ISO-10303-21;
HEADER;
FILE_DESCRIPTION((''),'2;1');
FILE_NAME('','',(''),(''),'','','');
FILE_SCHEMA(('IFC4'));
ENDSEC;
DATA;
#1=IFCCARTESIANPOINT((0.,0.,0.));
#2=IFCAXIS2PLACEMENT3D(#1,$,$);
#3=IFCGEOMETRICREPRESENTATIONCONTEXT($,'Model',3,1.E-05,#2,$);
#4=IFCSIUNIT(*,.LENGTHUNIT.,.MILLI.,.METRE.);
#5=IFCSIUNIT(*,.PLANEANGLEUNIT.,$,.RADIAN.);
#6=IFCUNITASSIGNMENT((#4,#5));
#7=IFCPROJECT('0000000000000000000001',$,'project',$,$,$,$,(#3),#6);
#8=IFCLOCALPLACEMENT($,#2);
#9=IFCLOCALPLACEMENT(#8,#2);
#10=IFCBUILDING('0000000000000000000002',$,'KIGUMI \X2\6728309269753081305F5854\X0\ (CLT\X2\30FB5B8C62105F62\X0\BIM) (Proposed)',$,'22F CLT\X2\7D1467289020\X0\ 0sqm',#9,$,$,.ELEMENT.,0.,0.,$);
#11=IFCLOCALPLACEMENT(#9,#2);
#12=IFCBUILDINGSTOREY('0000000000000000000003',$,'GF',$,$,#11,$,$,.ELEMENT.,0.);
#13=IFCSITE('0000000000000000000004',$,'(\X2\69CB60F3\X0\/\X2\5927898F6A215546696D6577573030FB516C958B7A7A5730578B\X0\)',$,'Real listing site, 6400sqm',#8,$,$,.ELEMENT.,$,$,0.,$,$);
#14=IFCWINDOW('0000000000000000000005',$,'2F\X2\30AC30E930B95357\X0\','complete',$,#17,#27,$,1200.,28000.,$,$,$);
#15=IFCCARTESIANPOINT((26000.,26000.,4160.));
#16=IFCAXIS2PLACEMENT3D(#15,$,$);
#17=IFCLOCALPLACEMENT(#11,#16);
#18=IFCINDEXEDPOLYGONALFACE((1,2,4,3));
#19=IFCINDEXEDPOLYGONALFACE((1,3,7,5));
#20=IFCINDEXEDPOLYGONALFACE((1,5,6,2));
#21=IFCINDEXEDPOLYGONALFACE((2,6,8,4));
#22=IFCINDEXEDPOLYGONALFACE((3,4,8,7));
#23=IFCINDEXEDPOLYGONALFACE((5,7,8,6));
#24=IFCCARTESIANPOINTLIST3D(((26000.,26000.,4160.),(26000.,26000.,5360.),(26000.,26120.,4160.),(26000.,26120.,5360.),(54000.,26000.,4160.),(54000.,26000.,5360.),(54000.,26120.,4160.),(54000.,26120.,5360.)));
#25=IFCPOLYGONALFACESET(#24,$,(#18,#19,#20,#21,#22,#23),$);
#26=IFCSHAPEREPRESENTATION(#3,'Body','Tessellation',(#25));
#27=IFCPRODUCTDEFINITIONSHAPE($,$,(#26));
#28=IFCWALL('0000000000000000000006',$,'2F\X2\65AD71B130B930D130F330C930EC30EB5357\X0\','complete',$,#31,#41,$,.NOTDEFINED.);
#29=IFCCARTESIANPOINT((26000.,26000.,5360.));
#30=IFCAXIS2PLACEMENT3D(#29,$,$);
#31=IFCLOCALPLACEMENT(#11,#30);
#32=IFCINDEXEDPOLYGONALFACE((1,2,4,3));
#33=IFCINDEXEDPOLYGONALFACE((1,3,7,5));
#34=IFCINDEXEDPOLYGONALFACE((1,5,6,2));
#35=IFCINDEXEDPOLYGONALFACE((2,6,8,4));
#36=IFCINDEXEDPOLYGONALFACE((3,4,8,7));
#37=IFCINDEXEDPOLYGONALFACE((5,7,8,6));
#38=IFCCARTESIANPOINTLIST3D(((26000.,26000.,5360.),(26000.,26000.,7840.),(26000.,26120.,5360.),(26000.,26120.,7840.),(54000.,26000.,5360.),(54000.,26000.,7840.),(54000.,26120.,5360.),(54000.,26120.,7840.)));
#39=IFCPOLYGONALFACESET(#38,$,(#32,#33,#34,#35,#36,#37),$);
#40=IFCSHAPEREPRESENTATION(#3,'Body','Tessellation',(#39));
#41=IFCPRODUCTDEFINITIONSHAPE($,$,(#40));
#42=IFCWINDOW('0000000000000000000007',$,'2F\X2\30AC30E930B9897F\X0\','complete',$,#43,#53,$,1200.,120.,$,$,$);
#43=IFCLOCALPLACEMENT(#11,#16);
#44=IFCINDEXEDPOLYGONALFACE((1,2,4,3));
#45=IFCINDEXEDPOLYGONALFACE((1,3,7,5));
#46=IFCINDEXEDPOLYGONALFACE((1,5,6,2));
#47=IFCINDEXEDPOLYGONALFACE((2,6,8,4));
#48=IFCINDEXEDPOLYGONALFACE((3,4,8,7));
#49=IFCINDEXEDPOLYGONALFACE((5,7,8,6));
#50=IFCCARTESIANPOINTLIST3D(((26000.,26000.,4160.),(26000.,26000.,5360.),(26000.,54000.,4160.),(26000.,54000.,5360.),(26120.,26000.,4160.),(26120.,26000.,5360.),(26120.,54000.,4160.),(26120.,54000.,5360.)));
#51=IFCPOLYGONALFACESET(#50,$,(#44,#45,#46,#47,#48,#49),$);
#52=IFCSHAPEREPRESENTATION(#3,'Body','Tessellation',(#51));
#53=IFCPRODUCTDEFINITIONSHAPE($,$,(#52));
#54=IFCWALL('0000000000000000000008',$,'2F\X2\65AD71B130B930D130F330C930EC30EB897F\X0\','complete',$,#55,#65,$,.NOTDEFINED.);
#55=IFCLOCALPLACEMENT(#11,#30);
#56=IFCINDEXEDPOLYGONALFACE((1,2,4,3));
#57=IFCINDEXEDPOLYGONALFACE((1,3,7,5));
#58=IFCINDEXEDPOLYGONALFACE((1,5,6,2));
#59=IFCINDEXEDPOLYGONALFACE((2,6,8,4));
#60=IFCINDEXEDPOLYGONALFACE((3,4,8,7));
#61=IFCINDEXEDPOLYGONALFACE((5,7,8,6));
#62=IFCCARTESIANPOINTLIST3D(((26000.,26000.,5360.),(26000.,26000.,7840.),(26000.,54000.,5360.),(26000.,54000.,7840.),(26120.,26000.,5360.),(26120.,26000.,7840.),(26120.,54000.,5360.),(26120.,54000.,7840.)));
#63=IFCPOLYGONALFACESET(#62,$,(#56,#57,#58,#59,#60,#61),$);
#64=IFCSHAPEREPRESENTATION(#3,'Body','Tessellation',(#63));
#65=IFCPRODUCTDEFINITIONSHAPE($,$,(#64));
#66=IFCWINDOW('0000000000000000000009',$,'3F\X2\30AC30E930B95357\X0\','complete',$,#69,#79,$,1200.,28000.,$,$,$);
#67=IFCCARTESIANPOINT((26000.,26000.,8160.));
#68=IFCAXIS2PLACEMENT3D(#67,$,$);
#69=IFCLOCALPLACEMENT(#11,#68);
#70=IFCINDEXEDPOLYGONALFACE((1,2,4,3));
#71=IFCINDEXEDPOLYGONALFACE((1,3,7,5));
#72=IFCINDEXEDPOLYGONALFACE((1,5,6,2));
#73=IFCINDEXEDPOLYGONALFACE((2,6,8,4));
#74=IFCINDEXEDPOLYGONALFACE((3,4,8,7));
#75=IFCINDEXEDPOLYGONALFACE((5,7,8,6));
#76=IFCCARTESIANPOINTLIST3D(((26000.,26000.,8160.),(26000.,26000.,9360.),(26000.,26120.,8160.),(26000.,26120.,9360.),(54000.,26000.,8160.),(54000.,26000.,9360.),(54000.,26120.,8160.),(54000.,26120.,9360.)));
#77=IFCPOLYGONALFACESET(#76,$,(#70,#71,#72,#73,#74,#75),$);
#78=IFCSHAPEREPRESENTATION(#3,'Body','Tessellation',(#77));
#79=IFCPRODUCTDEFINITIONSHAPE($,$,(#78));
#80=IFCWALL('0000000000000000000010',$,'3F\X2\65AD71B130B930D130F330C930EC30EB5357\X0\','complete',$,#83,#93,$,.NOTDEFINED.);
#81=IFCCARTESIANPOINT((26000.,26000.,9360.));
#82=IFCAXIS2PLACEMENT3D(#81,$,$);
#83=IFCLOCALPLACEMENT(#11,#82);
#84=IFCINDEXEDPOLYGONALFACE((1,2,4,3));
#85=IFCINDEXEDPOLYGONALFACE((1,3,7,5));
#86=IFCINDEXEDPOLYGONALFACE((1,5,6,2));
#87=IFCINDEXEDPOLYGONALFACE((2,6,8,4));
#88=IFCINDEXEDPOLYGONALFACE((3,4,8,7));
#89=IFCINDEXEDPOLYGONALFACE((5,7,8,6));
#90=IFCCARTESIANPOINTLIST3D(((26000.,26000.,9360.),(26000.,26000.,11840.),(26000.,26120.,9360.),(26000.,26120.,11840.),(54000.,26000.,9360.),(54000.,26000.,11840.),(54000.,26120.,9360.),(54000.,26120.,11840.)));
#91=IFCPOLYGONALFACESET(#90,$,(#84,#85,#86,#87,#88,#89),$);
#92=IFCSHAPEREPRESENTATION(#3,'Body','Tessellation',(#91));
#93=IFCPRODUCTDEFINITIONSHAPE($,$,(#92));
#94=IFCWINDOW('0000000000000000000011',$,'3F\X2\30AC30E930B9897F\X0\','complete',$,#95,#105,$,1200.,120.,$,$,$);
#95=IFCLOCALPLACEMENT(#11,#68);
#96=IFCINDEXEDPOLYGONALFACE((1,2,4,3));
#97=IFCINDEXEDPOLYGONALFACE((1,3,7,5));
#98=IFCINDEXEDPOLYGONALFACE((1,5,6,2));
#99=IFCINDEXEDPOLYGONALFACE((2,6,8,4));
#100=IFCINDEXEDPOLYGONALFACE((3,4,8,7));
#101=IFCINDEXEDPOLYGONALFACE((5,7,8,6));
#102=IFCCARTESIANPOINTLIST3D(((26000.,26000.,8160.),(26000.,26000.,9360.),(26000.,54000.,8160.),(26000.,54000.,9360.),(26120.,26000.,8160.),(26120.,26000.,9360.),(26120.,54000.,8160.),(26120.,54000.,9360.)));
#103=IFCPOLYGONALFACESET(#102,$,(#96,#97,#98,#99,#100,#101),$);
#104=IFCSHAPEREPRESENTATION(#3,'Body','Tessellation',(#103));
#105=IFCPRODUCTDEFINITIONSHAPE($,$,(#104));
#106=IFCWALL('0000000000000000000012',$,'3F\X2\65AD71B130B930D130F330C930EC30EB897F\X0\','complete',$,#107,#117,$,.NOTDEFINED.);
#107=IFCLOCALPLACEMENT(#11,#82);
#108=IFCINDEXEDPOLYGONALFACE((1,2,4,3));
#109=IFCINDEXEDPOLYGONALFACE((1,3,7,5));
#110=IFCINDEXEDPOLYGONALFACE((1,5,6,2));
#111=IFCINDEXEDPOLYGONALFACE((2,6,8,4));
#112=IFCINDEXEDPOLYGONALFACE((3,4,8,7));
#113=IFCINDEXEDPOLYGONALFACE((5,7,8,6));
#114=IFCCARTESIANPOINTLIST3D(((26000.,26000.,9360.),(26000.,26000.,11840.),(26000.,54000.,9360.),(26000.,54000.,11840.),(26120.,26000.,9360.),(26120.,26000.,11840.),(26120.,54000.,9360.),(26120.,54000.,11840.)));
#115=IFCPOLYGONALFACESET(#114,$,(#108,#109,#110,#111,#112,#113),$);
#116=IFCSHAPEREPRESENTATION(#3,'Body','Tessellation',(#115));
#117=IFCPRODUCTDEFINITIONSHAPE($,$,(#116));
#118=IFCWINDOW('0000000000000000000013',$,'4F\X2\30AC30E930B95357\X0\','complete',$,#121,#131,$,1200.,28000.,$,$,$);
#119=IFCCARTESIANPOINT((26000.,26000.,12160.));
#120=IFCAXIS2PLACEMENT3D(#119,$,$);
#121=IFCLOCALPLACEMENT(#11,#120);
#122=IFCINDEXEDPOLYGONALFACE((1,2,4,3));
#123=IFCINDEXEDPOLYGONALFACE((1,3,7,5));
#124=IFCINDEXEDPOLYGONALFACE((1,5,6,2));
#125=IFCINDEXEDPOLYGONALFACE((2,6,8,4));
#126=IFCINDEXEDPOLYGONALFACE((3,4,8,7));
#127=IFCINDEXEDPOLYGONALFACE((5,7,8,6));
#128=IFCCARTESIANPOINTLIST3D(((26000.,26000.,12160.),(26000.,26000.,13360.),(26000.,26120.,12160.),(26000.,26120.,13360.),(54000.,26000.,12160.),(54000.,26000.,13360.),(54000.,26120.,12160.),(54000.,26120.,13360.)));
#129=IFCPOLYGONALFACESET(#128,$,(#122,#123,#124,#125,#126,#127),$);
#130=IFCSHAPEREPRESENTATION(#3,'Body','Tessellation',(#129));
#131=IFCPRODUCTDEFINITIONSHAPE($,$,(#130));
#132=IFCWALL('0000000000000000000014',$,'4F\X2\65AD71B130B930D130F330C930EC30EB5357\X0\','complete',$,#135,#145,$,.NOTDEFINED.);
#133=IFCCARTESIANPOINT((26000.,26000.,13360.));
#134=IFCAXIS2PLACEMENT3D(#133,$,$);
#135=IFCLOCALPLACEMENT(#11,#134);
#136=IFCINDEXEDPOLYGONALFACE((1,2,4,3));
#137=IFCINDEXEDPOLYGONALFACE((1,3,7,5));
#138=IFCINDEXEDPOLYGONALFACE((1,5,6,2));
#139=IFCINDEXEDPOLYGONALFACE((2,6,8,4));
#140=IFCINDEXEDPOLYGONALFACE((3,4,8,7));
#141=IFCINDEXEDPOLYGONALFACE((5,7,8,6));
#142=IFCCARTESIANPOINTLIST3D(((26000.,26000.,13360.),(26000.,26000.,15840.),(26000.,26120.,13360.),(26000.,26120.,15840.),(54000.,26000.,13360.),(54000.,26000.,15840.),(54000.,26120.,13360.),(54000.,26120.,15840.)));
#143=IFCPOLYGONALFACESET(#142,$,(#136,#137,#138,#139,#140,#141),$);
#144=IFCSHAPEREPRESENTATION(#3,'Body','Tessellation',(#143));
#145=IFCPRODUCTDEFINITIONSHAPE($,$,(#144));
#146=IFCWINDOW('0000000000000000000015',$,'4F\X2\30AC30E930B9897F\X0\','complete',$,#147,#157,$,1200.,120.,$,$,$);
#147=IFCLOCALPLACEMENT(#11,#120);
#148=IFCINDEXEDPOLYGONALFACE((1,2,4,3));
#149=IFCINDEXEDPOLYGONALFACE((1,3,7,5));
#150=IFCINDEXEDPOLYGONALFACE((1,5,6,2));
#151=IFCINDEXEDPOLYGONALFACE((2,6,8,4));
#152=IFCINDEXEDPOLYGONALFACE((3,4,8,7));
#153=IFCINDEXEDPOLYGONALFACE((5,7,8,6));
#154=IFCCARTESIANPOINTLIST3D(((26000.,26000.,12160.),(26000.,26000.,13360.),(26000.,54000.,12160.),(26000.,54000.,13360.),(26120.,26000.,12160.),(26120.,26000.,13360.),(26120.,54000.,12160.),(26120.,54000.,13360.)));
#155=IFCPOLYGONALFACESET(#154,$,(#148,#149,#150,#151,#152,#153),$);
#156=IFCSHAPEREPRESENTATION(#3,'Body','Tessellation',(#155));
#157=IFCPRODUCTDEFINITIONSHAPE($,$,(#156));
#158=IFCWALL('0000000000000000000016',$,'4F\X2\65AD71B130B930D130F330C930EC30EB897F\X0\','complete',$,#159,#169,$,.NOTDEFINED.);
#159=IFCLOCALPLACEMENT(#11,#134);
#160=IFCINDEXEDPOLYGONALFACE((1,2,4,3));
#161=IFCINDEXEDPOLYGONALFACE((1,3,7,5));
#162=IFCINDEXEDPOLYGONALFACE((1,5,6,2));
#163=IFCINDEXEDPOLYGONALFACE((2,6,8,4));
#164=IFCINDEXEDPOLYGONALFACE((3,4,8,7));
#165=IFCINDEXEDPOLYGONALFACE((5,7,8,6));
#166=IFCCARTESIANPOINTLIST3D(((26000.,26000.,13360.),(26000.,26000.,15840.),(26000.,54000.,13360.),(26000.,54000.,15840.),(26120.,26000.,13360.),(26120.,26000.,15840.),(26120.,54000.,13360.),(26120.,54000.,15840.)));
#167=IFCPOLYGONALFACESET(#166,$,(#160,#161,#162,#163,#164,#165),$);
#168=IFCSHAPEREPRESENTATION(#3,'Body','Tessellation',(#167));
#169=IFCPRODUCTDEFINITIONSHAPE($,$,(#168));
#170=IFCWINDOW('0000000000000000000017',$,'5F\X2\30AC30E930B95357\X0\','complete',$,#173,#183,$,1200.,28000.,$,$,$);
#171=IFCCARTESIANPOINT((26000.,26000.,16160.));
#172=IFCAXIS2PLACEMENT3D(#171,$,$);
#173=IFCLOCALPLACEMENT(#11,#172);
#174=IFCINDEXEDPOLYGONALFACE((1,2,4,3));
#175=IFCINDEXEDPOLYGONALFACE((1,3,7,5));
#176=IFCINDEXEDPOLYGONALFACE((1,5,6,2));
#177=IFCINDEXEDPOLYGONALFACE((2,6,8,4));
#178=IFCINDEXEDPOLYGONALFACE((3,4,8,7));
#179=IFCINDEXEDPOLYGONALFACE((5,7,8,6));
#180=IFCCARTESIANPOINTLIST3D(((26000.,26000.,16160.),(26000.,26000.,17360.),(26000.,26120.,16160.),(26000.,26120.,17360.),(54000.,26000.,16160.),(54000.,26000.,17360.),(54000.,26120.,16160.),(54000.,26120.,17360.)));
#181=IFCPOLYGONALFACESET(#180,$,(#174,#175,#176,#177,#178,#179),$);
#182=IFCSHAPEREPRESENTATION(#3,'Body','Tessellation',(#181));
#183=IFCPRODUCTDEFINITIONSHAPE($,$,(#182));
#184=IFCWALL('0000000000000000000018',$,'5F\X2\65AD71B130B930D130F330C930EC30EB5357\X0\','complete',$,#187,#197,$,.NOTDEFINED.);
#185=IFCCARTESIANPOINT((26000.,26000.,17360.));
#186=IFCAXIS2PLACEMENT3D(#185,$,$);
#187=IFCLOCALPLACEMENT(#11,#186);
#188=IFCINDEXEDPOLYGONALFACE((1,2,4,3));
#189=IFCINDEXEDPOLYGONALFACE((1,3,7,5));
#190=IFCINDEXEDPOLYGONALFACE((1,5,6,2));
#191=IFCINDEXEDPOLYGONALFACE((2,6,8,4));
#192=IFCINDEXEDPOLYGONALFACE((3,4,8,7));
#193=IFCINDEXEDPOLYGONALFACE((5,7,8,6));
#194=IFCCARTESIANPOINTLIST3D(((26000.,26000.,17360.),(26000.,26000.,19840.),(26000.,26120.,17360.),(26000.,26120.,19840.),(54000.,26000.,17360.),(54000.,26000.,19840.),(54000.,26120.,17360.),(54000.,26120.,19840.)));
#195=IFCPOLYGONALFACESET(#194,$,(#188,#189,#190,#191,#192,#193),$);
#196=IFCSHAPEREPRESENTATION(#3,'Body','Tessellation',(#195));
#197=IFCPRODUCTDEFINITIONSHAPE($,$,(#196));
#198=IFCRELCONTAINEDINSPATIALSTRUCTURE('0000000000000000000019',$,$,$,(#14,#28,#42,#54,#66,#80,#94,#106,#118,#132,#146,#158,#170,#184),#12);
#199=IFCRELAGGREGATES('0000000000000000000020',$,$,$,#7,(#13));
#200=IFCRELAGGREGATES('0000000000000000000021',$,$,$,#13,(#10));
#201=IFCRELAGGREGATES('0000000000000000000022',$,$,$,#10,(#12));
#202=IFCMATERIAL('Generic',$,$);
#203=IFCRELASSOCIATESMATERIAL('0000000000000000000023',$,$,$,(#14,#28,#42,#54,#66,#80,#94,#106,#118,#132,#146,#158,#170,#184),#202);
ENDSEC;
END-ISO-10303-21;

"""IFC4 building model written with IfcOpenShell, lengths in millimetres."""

from ifc_helpers import new_model, si_unit, frame, frame_2d, origin, place, context, project, spatial, rectangle, extrude, material, element, save


model = new_model("IFC4")

# Units and contexts
model_context = context("Model", 3, precision=1e-05, world=origin())
ifc_project = project(units=[si_unit("LENGTHUNIT", "METRE", prefix="MILLI"), si_unit("PLANEANGLEUNIT", "RADIAN")], contexts=[model_context])

# Site, building, storey
site_placement = place(None, origin())
site = spatial("IfcSite", under=ifc_project, at=site_placement, Name="(構想/大規模商業敷地・公開空地型)", ObjectType="Real listing site, 6400sqm", CompositionType="ELEMENT", RefElevation=0.0)
building_placement = place(site_placement, origin())
building = spatial("IfcBuilding", under=site, at=building_placement, Name="KIGUMI 木を極めた塔 (CLT・完成形BIM) (Proposed)", ObjectType="22F CLT純木造 0sqm", CompositionType="ELEMENT", ElevationOfRefHeight=0.0, ElevationOfTerrain=0.0)
storey_placement = place(building_placement, origin())
storey = spatial("IfcBuildingStorey", under=building, at=storey_placement, Name="GF", CompositionType="ELEMENT", Elevation=0.0)

# Shared definitions
ifc_material = material(Name="Generic")

# Window
window_1_placement = place(storey_placement, frame((26000.0, 26000.0, 4160.0)))
element("IfcWindow", 1, at=window_1_placement, inside=storey, material=ifc_material, Name="2Fガラス南", Description="complete", OverallHeight=1200.0, OverallWidth=28000.0, context=model_context, shape_type="SweptSolid", body=[
    extrude(rectangle(XDim=28000.0, YDim=120.0, at=frame_2d((14000.0, 60.0))), frame((26000.0, 26000.0, 4160.0)), (0.0, 0.0, 1.0), 1200.0),
])

# Wall
wall_1_placement = place(storey_placement, frame((26000.0, 26000.0, 5360.0)))
element("IfcWall", 2, at=wall_1_placement, inside=storey, material=ifc_material, Name="2F断熱スパンドレル南", Description="complete", PredefinedType="NOTDEFINED", context=model_context, shape_type="SweptSolid", body=[
    extrude(rectangle(XDim=28000.0, YDim=120.0, at=frame_2d((14000.0, 60.0))), frame((26000.0, 26000.0, 5360.0)), (0.0, 0.0, 1.0), 2480.0),
])

# Window
window_2_placement = place(storey_placement, frame((26000.0, 26000.0, 4160.0)))
element("IfcWindow", 3, at=window_2_placement, inside=storey, material=ifc_material, Name="2Fガラス西", Description="complete", OverallHeight=1200.0, OverallWidth=120.0, context=model_context, shape_type="SweptSolid", body=[
    extrude(rectangle(XDim=120.0, YDim=28000.0, at=frame_2d((60.0, 14000.0))), frame((26000.0, 26000.0, 4160.0)), (0.0, 0.0, 1.0), 1200.0),
])

# Wall
wall_2_placement = place(storey_placement, frame((26000.0, 26000.0, 5360.0)))
element("IfcWall", 4, at=wall_2_placement, inside=storey, material=ifc_material, Name="2F断熱スパンドレル西", Description="complete", PredefinedType="NOTDEFINED", context=model_context, shape_type="SweptSolid", body=[
    extrude(rectangle(XDim=120.0, YDim=28000.0, at=frame_2d((60.0, 14000.0))), frame((26000.0, 26000.0, 5360.0)), (0.0, 0.0, 1.0), 2480.0),
])

# Window
window_3_placement = place(storey_placement, frame((26000.0, 26000.0, 8160.0)))
element("IfcWindow", 5, at=window_3_placement, inside=storey, material=ifc_material, Name="3Fガラス南", Description="complete", OverallHeight=1200.0, OverallWidth=28000.0, context=model_context, shape_type="SweptSolid", body=[
    extrude(rectangle(XDim=28000.0, YDim=120.0, at=frame_2d((14000.0, 60.0))), frame((26000.0, 26000.0, 8160.0)), (0.0, 0.0, 1.0), 1200.0),
])

# Wall
wall_3_placement = place(storey_placement, frame((26000.0, 26000.0, 9360.0)))
element("IfcWall", 6, at=wall_3_placement, inside=storey, material=ifc_material, Name="3F断熱スパンドレル南", Description="complete", PredefinedType="NOTDEFINED", context=model_context, shape_type="SweptSolid", body=[
    extrude(rectangle(XDim=28000.0, YDim=120.0, at=frame_2d((14000.0, 60.0))), frame((26000.0, 26000.0, 9360.0)), (0.0, 0.0, 1.0), 2480.0),
])

# Window
window_4_placement = place(storey_placement, frame((26000.0, 26000.0, 8160.0)))
element("IfcWindow", 7, at=window_4_placement, inside=storey, material=ifc_material, Name="3Fガラス西", Description="complete", OverallHeight=1200.0, OverallWidth=120.0, context=model_context, shape_type="SweptSolid", body=[
    extrude(rectangle(XDim=120.0, YDim=28000.0, at=frame_2d((60.0, 14000.0))), frame((26000.0, 26000.0, 8160.0)), (0.0, 0.0, 1.0), 1200.0),
])

# Wall
wall_4_placement = place(storey_placement, frame((26000.0, 26000.0, 9360.0)))
element("IfcWall", 8, at=wall_4_placement, inside=storey, material=ifc_material, Name="3F断熱スパンドレル西", Description="complete", PredefinedType="NOTDEFINED", context=model_context, shape_type="SweptSolid", body=[
    extrude(rectangle(XDim=120.0, YDim=28000.0, at=frame_2d((60.0, 14000.0))), frame((26000.0, 26000.0, 9360.0)), (0.0, 0.0, 1.0), 2480.0),
])

# Window
window_5_placement = place(storey_placement, frame((26000.0, 26000.0, 12160.0)))
element("IfcWindow", 9, at=window_5_placement, inside=storey, material=ifc_material, Name="4Fガラス南", Description="complete", OverallHeight=1200.0, OverallWidth=28000.0, context=model_context, shape_type="SweptSolid", body=[
    extrude(rectangle(XDim=28000.0, YDim=120.0, at=frame_2d((14000.0, 60.0))), frame((26000.0, 26000.0, 12160.0)), (0.0, 0.0, 1.0), 1200.0),
])

# Wall
wall_5_placement = place(storey_placement, frame((26000.0, 26000.0, 13360.0)))
element("IfcWall", 10, at=wall_5_placement, inside=storey, material=ifc_material, Name="4F断熱スパンドレル南", Description="complete", PredefinedType="NOTDEFINED", context=model_context, shape_type="SweptSolid", body=[
    extrude(rectangle(XDim=28000.0, YDim=120.0, at=frame_2d((14000.0, 60.0))), frame((26000.0, 26000.0, 13360.0)), (0.0, 0.0, 1.0), 2480.0),
])

# Window
window_6_placement = place(storey_placement, frame((26000.0, 26000.0, 12160.0)))
element("IfcWindow", 11, at=window_6_placement, inside=storey, material=ifc_material, Name="4Fガラス西", Description="complete", OverallHeight=1200.0, OverallWidth=120.0, context=model_context, shape_type="SweptSolid", body=[
    extrude(rectangle(XDim=120.0, YDim=28000.0, at=frame_2d((60.0, 14000.0))), frame((26000.0, 26000.0, 12160.0)), (0.0, 0.0, 1.0), 1200.0),
])

# Wall
wall_6_placement = place(storey_placement, frame((26000.0, 26000.0, 13360.0)))
element("IfcWall", 12, at=wall_6_placement, inside=storey, material=ifc_material, Name="4F断熱スパンドレル西", Description="complete", PredefinedType="NOTDEFINED", context=model_context, shape_type="SweptSolid", body=[
    extrude(rectangle(XDim=120.0, YDim=28000.0, at=frame_2d((60.0, 14000.0))), frame((26000.0, 26000.0, 13360.0)), (0.0, 0.0, 1.0), 2480.0),
])

# Window
window_7_placement = place(storey_placement, frame((26000.0, 26000.0, 16160.0)))
element("IfcWindow", 13, at=window_7_placement, inside=storey, material=ifc_material, Name="5Fガラス南", Description="complete", OverallHeight=1200.0, OverallWidth=28000.0, context=model_context, shape_type="SweptSolid", body=[
    extrude(rectangle(XDim=28000.0, YDim=120.0, at=frame_2d((14000.0, 60.0))), frame((26000.0, 26000.0, 16160.0)), (0.0, 0.0, 1.0), 1200.0),
])

# Wall
wall_7_placement = place(storey_placement, frame((26000.0, 26000.0, 17360.0)))
element("IfcWall", 14, at=wall_7_placement, inside=storey, material=ifc_material, Name="5F断熱スパンドレル南", Description="complete", PredefinedType="NOTDEFINED", context=model_context, shape_type="SweptSolid", body=[
    extrude(rectangle(XDim=28000.0, YDim=120.0, at=frame_2d((14000.0, 60.0))), frame((26000.0, 26000.0, 17360.0)), (0.0, 0.0, 1.0), 2480.0),
])

save(model, "model.ifc")
